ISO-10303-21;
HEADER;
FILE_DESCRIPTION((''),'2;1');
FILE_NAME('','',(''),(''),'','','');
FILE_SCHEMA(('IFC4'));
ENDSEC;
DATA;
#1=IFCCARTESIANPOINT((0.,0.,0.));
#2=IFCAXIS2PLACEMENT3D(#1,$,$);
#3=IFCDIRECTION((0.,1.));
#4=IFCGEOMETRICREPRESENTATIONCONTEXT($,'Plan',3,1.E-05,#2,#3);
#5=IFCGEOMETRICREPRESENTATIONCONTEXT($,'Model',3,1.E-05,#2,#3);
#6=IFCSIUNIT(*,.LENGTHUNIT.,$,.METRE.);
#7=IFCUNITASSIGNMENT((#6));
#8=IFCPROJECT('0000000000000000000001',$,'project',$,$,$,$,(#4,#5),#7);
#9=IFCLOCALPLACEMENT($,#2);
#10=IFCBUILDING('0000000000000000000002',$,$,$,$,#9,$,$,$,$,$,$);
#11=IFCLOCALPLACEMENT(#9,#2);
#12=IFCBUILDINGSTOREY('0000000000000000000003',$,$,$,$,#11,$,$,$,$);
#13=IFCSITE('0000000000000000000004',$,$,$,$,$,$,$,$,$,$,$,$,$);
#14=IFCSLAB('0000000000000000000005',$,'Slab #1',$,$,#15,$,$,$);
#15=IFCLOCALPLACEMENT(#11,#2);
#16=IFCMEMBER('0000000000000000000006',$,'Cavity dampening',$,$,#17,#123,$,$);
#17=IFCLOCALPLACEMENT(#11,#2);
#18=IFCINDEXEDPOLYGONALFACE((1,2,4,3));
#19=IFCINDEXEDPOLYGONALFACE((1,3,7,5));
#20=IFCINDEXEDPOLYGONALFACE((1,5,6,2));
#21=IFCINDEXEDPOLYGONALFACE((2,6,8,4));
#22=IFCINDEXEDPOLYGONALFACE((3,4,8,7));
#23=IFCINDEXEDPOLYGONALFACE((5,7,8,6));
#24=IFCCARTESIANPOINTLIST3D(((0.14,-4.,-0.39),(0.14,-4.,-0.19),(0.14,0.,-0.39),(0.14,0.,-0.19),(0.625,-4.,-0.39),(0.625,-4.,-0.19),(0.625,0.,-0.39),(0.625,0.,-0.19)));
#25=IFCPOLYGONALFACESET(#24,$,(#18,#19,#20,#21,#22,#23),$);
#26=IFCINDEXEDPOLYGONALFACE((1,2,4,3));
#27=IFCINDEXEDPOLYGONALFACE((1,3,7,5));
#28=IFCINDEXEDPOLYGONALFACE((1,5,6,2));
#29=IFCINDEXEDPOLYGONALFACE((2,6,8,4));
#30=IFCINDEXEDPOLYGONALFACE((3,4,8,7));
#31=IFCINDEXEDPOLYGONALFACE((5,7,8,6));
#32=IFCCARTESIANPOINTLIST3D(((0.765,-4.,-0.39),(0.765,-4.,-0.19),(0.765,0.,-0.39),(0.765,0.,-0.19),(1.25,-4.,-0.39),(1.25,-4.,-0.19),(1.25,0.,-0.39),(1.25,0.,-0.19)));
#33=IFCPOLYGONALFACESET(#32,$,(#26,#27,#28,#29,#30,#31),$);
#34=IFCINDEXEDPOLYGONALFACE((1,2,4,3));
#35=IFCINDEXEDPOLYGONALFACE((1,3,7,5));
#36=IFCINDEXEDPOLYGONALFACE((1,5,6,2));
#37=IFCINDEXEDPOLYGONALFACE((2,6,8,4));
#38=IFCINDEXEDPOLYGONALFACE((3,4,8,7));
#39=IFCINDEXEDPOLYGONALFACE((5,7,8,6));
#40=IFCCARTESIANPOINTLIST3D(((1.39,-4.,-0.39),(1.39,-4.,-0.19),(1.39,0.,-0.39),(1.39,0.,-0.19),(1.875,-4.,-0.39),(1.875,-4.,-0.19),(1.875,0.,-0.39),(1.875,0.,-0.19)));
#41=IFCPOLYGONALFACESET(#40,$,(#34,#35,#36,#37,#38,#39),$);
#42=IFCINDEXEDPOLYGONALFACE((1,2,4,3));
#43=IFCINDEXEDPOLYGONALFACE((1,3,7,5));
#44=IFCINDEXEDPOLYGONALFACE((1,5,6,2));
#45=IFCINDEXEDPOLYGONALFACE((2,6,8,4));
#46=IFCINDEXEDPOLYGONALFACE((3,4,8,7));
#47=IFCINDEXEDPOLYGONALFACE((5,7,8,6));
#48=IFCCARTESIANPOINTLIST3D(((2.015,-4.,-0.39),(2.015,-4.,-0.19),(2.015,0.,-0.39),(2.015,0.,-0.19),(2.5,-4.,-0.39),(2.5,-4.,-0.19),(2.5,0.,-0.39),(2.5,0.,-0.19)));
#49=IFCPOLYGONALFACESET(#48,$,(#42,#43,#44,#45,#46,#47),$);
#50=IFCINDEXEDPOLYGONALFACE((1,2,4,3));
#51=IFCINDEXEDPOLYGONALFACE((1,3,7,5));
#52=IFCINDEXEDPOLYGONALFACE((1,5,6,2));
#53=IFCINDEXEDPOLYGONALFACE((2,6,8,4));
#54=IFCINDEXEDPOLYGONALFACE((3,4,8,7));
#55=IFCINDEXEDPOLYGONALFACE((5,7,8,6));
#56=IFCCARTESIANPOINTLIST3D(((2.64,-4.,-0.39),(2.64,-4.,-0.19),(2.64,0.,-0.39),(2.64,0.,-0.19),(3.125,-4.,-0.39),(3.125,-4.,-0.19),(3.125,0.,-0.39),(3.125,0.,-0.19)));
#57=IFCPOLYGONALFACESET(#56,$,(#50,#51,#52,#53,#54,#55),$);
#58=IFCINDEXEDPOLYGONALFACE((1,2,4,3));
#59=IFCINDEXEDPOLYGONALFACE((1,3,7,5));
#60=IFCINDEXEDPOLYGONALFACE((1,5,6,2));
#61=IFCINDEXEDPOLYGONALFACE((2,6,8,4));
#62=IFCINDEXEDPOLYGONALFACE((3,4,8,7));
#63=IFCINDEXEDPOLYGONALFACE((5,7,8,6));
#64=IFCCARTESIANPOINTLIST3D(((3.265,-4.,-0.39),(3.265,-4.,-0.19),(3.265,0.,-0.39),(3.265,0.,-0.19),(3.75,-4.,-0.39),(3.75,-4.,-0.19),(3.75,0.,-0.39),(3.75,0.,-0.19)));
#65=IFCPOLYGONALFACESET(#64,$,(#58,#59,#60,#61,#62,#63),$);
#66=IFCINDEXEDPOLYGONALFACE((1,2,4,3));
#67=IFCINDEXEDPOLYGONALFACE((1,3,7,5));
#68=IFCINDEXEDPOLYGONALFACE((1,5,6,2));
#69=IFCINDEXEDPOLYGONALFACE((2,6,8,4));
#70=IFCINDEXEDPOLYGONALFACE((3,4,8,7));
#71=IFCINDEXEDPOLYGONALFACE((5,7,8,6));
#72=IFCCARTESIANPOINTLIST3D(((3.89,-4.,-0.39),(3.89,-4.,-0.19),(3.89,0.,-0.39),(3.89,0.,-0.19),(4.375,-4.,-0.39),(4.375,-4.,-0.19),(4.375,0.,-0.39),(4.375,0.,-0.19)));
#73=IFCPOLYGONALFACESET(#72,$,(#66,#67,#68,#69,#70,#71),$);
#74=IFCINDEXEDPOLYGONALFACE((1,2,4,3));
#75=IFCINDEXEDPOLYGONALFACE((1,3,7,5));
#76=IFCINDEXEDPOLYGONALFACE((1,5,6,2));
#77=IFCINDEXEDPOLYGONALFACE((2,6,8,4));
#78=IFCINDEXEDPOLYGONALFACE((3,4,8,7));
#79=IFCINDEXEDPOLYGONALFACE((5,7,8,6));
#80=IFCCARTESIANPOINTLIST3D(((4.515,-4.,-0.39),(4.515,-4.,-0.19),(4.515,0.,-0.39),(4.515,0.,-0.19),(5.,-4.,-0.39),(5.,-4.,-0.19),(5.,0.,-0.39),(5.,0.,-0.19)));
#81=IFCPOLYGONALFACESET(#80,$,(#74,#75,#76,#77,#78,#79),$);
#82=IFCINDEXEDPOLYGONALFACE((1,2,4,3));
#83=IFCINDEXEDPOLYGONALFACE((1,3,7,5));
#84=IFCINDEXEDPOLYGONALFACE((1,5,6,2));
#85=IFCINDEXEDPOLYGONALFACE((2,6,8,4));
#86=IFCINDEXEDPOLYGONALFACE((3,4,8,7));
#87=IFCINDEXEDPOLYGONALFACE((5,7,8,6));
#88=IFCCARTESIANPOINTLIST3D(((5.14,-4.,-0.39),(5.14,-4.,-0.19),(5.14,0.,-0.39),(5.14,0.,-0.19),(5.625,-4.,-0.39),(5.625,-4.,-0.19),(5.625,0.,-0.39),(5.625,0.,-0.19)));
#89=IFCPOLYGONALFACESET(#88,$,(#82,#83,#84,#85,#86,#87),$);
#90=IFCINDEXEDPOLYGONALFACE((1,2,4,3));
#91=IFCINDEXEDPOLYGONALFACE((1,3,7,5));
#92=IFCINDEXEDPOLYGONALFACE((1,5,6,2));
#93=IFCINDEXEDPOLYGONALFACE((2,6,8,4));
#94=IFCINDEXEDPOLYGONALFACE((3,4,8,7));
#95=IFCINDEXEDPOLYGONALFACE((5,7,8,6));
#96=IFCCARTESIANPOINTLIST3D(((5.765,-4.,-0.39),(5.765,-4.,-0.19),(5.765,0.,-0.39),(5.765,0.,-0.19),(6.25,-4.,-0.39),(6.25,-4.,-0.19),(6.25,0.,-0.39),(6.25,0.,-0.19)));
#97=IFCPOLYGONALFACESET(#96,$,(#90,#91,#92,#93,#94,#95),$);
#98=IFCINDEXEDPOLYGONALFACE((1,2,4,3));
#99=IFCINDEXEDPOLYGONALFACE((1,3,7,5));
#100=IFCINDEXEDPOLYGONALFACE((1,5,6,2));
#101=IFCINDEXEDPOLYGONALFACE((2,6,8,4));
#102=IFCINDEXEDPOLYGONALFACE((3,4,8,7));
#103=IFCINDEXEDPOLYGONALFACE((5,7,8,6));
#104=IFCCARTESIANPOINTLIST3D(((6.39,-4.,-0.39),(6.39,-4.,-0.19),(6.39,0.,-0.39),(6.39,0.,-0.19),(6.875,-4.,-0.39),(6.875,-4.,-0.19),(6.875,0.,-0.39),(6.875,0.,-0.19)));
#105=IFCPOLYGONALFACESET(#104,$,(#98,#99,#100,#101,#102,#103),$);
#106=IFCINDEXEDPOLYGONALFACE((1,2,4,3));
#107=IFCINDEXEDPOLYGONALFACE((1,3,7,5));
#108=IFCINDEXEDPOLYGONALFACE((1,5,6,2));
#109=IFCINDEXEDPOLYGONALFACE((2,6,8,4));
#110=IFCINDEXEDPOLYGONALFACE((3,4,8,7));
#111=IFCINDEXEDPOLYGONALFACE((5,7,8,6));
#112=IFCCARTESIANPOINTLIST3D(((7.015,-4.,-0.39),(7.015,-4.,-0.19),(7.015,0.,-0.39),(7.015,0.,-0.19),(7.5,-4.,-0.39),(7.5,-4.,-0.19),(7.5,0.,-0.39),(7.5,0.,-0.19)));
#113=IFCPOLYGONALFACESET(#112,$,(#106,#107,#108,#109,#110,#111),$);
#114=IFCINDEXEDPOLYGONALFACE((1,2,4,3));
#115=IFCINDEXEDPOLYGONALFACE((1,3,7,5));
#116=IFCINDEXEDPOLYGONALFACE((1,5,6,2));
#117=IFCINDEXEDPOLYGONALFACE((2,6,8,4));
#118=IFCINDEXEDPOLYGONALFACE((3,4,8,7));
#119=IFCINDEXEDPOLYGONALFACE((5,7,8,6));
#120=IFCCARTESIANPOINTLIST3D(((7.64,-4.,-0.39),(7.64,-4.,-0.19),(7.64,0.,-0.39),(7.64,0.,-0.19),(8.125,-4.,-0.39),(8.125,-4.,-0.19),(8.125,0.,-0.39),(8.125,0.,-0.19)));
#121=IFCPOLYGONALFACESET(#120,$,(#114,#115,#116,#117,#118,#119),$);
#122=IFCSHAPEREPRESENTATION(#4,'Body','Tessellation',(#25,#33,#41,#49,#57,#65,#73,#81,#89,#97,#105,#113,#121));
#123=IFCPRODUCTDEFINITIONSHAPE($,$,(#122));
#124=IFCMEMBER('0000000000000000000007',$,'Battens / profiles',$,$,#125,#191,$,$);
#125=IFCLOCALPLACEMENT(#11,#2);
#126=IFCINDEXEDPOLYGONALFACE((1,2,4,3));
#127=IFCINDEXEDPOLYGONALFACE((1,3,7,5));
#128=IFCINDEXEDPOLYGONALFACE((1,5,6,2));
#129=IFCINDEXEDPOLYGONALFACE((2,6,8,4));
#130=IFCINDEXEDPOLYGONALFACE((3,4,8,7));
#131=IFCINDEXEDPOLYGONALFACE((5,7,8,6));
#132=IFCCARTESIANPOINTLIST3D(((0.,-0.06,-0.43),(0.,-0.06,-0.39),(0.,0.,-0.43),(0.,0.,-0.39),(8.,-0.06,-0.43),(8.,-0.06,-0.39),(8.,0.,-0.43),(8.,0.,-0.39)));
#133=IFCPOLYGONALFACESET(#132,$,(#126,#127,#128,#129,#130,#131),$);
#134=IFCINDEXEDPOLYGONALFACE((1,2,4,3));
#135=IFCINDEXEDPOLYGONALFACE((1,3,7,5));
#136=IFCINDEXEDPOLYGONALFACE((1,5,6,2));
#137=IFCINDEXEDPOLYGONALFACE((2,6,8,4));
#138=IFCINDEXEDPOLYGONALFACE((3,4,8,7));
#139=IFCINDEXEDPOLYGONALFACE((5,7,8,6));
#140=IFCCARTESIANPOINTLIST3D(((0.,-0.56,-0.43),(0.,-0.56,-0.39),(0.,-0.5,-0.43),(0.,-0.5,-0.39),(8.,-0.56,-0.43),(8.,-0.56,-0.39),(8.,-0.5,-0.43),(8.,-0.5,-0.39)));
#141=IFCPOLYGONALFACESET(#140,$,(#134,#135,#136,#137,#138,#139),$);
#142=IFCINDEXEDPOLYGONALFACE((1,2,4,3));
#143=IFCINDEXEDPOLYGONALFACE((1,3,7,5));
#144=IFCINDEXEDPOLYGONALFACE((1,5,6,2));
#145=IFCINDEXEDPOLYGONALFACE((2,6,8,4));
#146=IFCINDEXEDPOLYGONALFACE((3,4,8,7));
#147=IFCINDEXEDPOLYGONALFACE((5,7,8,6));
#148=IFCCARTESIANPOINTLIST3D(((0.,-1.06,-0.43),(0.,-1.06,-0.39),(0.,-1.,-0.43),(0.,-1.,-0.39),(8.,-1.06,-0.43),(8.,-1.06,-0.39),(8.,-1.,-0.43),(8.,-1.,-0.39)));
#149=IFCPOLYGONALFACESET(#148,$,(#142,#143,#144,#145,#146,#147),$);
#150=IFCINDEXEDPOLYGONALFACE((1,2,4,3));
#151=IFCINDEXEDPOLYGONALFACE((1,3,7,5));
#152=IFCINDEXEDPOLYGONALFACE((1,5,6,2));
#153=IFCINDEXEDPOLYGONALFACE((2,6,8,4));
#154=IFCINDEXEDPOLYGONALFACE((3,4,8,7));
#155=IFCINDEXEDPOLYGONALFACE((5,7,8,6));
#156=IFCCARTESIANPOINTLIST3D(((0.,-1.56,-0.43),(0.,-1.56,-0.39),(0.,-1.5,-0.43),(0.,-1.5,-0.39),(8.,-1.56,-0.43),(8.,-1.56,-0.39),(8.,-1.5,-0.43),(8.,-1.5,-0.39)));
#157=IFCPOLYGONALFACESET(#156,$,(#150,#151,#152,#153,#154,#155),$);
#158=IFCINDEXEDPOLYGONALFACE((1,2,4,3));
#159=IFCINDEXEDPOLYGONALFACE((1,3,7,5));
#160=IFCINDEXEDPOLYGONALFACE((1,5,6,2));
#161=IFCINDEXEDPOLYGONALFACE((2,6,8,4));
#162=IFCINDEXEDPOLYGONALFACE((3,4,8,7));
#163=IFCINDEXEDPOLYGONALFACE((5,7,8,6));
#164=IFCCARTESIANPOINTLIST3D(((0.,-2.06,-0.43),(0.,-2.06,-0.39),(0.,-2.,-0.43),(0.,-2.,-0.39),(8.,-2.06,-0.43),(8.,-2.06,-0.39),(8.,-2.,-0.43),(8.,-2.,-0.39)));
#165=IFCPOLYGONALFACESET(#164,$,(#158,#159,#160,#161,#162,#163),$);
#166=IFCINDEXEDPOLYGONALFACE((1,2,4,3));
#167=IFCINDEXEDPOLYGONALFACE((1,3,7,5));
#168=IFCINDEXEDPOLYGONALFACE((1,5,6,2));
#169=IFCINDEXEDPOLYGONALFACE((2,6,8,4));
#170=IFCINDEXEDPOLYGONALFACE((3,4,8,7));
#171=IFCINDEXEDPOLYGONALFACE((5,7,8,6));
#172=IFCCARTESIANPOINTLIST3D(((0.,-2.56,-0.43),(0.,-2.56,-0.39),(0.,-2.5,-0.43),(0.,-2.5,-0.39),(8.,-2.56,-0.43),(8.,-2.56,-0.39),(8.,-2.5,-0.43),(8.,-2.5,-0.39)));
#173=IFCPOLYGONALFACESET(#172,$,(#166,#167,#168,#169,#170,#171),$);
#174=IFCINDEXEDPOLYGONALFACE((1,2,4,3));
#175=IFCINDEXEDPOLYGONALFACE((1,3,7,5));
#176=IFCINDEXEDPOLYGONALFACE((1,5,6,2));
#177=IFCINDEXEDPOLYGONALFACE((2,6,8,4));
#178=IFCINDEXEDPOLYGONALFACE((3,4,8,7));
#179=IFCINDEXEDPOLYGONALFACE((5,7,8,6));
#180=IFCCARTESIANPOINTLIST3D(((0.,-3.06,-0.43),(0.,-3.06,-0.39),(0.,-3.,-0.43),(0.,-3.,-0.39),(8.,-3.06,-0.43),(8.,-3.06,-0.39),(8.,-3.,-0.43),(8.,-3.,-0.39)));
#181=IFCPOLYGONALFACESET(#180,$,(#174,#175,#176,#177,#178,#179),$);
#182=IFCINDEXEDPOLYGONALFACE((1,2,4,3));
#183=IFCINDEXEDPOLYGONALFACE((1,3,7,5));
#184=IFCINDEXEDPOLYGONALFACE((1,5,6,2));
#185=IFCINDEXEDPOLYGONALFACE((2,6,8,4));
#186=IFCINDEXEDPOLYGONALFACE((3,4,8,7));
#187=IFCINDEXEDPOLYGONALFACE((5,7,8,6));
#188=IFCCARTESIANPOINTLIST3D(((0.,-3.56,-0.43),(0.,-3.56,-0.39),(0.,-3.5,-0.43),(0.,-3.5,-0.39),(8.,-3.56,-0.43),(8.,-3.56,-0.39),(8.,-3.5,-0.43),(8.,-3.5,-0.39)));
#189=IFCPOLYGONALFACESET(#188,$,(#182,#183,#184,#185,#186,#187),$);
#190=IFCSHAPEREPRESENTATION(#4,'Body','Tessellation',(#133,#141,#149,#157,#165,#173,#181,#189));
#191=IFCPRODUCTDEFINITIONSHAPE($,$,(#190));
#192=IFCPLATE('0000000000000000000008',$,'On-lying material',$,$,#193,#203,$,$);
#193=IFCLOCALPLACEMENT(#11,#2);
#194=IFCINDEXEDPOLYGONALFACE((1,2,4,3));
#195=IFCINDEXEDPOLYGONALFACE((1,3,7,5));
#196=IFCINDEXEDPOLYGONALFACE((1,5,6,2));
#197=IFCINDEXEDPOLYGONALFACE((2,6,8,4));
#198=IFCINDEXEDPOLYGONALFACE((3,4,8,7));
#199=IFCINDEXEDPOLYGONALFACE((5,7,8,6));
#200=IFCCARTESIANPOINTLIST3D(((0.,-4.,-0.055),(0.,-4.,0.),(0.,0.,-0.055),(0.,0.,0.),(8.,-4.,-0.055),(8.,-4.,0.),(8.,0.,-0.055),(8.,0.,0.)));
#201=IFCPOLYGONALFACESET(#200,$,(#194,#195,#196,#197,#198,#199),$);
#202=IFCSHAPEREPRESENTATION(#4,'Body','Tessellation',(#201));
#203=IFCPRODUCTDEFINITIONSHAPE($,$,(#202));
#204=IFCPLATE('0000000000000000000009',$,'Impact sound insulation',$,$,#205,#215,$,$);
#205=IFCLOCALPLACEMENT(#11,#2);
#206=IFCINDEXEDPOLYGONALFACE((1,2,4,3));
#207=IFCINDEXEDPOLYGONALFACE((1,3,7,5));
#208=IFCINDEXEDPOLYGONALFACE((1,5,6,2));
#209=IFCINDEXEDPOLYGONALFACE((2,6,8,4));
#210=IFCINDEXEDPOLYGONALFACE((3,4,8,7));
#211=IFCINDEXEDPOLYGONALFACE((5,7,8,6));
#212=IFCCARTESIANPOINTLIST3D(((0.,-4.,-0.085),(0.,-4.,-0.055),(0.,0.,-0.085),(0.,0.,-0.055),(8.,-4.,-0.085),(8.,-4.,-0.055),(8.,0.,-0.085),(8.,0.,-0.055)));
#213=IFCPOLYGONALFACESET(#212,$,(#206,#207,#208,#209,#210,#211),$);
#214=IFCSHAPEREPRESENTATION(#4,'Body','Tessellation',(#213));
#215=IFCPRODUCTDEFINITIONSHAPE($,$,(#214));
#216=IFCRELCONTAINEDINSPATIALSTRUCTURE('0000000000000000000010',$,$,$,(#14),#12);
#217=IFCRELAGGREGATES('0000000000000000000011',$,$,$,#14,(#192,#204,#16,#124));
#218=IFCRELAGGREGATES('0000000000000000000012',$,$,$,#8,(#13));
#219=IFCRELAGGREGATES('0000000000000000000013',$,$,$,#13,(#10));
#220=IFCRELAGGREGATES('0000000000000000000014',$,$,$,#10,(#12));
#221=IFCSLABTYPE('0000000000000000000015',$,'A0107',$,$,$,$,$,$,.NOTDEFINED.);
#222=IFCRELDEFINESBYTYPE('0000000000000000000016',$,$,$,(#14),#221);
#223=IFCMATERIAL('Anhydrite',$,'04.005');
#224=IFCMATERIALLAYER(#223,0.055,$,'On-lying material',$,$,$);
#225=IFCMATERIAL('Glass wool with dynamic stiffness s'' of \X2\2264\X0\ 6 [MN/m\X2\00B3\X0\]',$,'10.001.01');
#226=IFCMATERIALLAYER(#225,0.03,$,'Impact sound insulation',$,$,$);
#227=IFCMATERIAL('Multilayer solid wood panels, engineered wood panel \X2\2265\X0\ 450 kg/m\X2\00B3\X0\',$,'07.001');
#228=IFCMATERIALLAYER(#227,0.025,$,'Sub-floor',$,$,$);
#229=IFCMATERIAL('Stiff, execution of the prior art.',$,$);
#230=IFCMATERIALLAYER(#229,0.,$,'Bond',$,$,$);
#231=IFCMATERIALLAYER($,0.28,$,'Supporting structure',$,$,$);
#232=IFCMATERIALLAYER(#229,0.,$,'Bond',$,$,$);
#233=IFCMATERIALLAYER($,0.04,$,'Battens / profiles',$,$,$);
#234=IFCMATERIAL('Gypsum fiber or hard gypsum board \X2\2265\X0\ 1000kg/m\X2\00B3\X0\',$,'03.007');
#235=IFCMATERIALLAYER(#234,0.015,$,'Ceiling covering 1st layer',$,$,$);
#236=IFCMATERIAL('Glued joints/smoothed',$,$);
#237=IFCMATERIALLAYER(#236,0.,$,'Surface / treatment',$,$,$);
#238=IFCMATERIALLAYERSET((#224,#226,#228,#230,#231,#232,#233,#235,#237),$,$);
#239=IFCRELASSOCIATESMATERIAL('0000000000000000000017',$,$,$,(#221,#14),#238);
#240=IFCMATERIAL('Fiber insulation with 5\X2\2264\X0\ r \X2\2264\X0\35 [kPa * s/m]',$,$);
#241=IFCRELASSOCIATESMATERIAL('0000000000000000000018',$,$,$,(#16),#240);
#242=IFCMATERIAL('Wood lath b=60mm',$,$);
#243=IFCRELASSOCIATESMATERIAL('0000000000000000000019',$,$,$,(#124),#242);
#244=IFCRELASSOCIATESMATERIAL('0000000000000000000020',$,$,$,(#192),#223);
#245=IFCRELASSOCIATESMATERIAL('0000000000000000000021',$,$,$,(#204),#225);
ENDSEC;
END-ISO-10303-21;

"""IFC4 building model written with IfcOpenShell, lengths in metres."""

from ifc_helpers import new_model, si_unit, direction, frame, frame_2d, origin, origin_with_axes, place, context, project, spatial, rectangle, extrude, material, layer, layer_set, type_object, element, aggregate, save


model = new_model("IFC4")

# Units and contexts
plan_context = context("Plan", 3, precision=1e-05, world=origin(), true_north=direction((0.0, 1.0)))
model_context = context("Model", 3, precision=1e-05, world=origin(), true_north=direction((0.0, 1.0)))
ifc_project = project(units=[si_unit("LENGTHUNIT", "METRE")], contexts=[plan_context, model_context])

# Site, building, storey
site = spatial("IfcSite", under=ifc_project)
building_placement = place(None, origin())
building = spatial("IfcBuilding", under=site, at=building_placement)
storey_placement = place(building_placement, origin())
storey = spatial("IfcBuildingStorey", under=building, at=storey_placement)

# Slab, members, plates
ifc_material_1 = material(Name="Anhydrite", Category="04.005")
ifc_layer_1 = layer(ifc_material_1, 0.055, Name="On-lying material")
ifc_material_2 = material(Name="Glass wool with dynamic stiffness s' of ≤ 6 [MN/m³]", Category="10.001.01")
ifc_layer_2 = layer(ifc_material_2, 0.03, Name="Impact sound insulation")
ifc_material_3 = material(Name="Multilayer solid wood panels, engineered wood panel ≥ 450 kg/m³", Category="07.001")
ifc_layer_3 = layer(ifc_material_3, 0.025, Name="Sub-floor")
ifc_material_4 = material(Name="Stiff, execution of the prior art.")
ifc_layer_4 = layer(ifc_material_4, 0.0, Name="Bond")
ifc_layer_5 = layer(None, 0.28, Name="Supporting structure")
ifc_layer_6 = layer(ifc_material_4, 0.0, Name="Bond")
ifc_layer_7 = layer(None, 0.04, Name="Battens / profiles")
ifc_material_5 = material(Name="Gypsum fiber or hard gypsum board ≥ 1000kg/m³", Category="03.007")
ifc_layer_8 = layer(ifc_material_5, 0.015, Name="Ceiling covering 1st layer")
ifc_material_6 = material(Name="Glued joints/smoothed")
ifc_layer_9 = layer(ifc_material_6, 0.0, Name="Surface / treatment")
ifc_layer_set = layer_set([ifc_layer_1, ifc_layer_2, ifc_layer_3, ifc_layer_4, ifc_layer_5, ifc_layer_6, ifc_layer_7, ifc_layer_8, ifc_layer_9])
slab_type = type_object("IfcSlabType", Name="A0107", PredefinedType="NOTDEFINED", material=ifc_layer_set)
slab_placement = place(None, frame((0.0, 0.0, 0.0), z_axis=(0.0, 0.0, -1.0), x_axis=(1.0, 0.0, 0.0)))
slab = element("IfcSlab", 1, at=slab_placement, inside=storey, type_object=slab_type, material=ifc_layer_set, Name="Slab #1")
ifc_material_7 = material(Name="Fiber insulation with 5≤ r ≤35 [kPa * s/m]")
member_1_placement = place(slab_placement, origin())
member_1 = element("IfcMember", 2, at=member_1_placement, material=ifc_material_7, Name="Cavity dampening", context=plan_context, shape_type="SweptSolid", body=[
    extrude(rectangle(XDim=0.485, YDim=0.2, at=frame_2d((0.2425, 0.1), x_axis=(1.0, 0.0))), frame((0.14, 4.0, 0.19), z_axis=(0.0, -1.0, 0.0), x_axis=(1.0, 0.0, 0.0)), (0.0, 0.0, 1.0), 4.0),
    extrude(rectangle(XDim=0.485, YDim=0.2, at=frame_2d((0.2425, 0.1), x_axis=(1.0, 0.0))), frame((0.765, 4.0, 0.19), z_axis=(0.0, -1.0, 0.0), x_axis=(1.0, 0.0, 0.0)), (0.0, 0.0, 1.0), 4.0),
    extrude(rectangle(XDim=0.485, YDim=0.2, at=frame_2d((0.2425, 0.1), x_axis=(1.0, 0.0))), frame((1.39, 4.0, 0.19), z_axis=(0.0, -1.0, 0.0), x_axis=(1.0, 0.0, 0.0)), (0.0, 0.0, 1.0), 4.0),
    extrude(rectangle(XDim=0.485, YDim=0.2, at=frame_2d((0.2425, 0.1), x_axis=(1.0, 0.0))), frame((2.015, 4.0, 0.19), z_axis=(0.0, -1.0, 0.0), x_axis=(1.0, 0.0, 0.0)), (0.0, 0.0, 1.0), 4.0),
    extrude(rectangle(XDim=0.485, YDim=0.2, at=frame_2d((0.2425, 0.1), x_axis=(1.0, 0.0))), frame((2.64, 4.0, 0.19), z_axis=(0.0, -1.0, 0.0), x_axis=(1.0, 0.0, 0.0)), (0.0, 0.0, 1.0), 4.0),
    extrude(rectangle(XDim=0.485, YDim=0.2, at=frame_2d((0.2425, 0.1), x_axis=(1.0, 0.0))), frame((3.265, 4.0, 0.19), z_axis=(0.0, -1.0, 0.0), x_axis=(1.0, 0.0, 0.0)), (0.0, 0.0, 1.0), 4.0),
    extrude(rectangle(XDim=0.485, YDim=0.2, at=frame_2d((0.2425, 0.1), x_axis=(1.0, 0.0))), frame((3.89, 4.0, 0.19), z_axis=(0.0, -1.0, 0.0), x_axis=(1.0, 0.0, 0.0)), (0.0, 0.0, 1.0), 4.0),
    extrude(rectangle(XDim=0.485, YDim=0.2, at=frame_2d((0.2425, 0.1), x_axis=(1.0, 0.0))), frame((4.515, 4.0, 0.19), z_axis=(0.0, -1.0, 0.0), x_axis=(1.0, 0.0, 0.0)), (0.0, 0.0, 1.0), 4.0),
    extrude(rectangle(XDim=0.485, YDim=0.2, at=frame_2d((0.2425, 0.1), x_axis=(1.0, 0.0))), frame((5.14, 4.0, 0.19), z_axis=(0.0, -1.0, 0.0), x_axis=(1.0, 0.0, 0.0)), (0.0, 0.0, 1.0), 4.0),
    extrude(rectangle(XDim=0.485, YDim=0.2, at=frame_2d((0.2425, 0.1), x_axis=(1.0, 0.0))), frame((5.765, 4.0, 0.19), z_axis=(0.0, -1.0, 0.0), x_axis=(1.0, 0.0, 0.0)), (0.0, 0.0, 1.0), 4.0),
    extrude(rectangle(XDim=0.485, YDim=0.2, at=frame_2d((0.2425, 0.1), x_axis=(1.0, 0.0))), frame((6.39, 4.0, 0.19), z_axis=(0.0, -1.0, 0.0), x_axis=(1.0, 0.0, 0.0)), (0.0, 0.0, 1.0), 4.0),
    extrude(rectangle(XDim=0.485, YDim=0.2, at=frame_2d((0.2425, 0.1), x_axis=(1.0, 0.0))), frame((7.015, 4.0, 0.19), z_axis=(0.0, -1.0, 0.0), x_axis=(1.0, 0.0, 0.0)), (0.0, 0.0, 1.0), 4.0),
    extrude(rectangle(XDim=0.485, YDim=0.2, at=frame_2d((0.2425, 0.1), x_axis=(1.0, 0.0))), frame((7.64, 4.0, 0.19), z_axis=(0.0, -1.0, 0.0), x_axis=(1.0, 0.0, 0.0)), (0.0, 0.0, 1.0), 4.0),
])
ifc_material_8 = material(Name="Wood lath b=60mm")
member_2_placement = place(slab_placement, origin())
member_2 = element("IfcMember", 3, at=member_2_placement, material=ifc_material_8, Name="Battens / profiles", context=plan_context, shape_type="SweptSolid", body=[
    extrude(rectangle(XDim=0.06, YDim=0.04, at=frame_2d((0.03, 0.02), x_axis=(1.0, 0.0))), frame((0.0, 0.0, 0.39), z_axis=(1.0, 0.0, 0.0), x_axis=(0.0, 1.0, 0.0)), (0.0, 0.0, 1.0), 8.0),
    extrude(rectangle(XDim=0.06, YDim=0.04, at=frame_2d((0.03, 0.02), x_axis=(1.0, 0.0))), frame((0.0, 0.5, 0.39), z_axis=(1.0, 0.0, 0.0), x_axis=(0.0, 1.0, 0.0)), (0.0, 0.0, 1.0), 8.0),
    extrude(rectangle(XDim=0.06, YDim=0.04, at=frame_2d((0.03, 0.02), x_axis=(1.0, 0.0))), frame((0.0, 1.0, 0.39), z_axis=(1.0, 0.0, 0.0), x_axis=(0.0, 1.0, 0.0)), (0.0, 0.0, 1.0), 8.0),
    extrude(rectangle(XDim=0.06, YDim=0.04, at=frame_2d((0.03, 0.02), x_axis=(1.0, 0.0))), frame((0.0, 1.5, 0.39), z_axis=(1.0, 0.0, 0.0), x_axis=(0.0, 1.0, 0.0)), (0.0, 0.0, 1.0), 8.0),
    extrude(rectangle(XDim=0.06, YDim=0.04, at=frame_2d((0.03, 0.02), x_axis=(1.0, 0.0))), frame((0.0, 2.0, 0.39), z_axis=(1.0, 0.0, 0.0), x_axis=(0.0, 1.0, 0.0)), (0.0, 0.0, 1.0), 8.0),
    extrude(rectangle(XDim=0.06, YDim=0.04, at=frame_2d((0.03, 0.02), x_axis=(1.0, 0.0))), frame((0.0, 2.5, 0.39), z_axis=(1.0, 0.0, 0.0), x_axis=(0.0, 1.0, 0.0)), (0.0, 0.0, 1.0), 8.0),
    extrude(rectangle(XDim=0.06, YDim=0.04, at=frame_2d((0.03, 0.02), x_axis=(1.0, 0.0))), frame((0.0, 3.0, 0.39), z_axis=(1.0, 0.0, 0.0), x_axis=(0.0, 1.0, 0.0)), (0.0, 0.0, 1.0), 8.0),
    extrude(rectangle(XDim=0.06, YDim=0.04, at=frame_2d((0.03, 0.02), x_axis=(1.0, 0.0))), frame((0.0, 3.5, 0.39), z_axis=(1.0, 0.0, 0.0), x_axis=(0.0, 1.0, 0.0)), (0.0, 0.0, 1.0), 8.0),
])
plate_1_placement = place(slab_placement, origin())
plate_1 = element("IfcPlate", 4, at=plate_1_placement, material=ifc_material_1, Name="On-lying material", context=plan_context, shape_type="SweptSolid", body=[
    extrude(rectangle(XDim=8.0, YDim=4.0, at=frame_2d((4.0, 2.0), x_axis=(1.0, 0.0))), origin_with_axes(), (0.0, 0.0, 1.0), 0.055),
])
plate_2_placement = place(slab_placement, origin())
plate_2 = element("IfcPlate", 5, at=plate_2_placement, material=ifc_material_2, Name="Impact sound insulation", context=plan_context, shape_type="SweptSolid", body=[
    extrude(rectangle(XDim=8.0, YDim=4.0, at=frame_2d((4.0, 2.0), x_axis=(1.0, 0.0))), frame((0.0, 0.0, 0.055), z_axis=(0.0, 0.0, 1.0), x_axis=(1.0, 0.0, 0.0)), (0.0, 0.0, 1.0), 0.03),
])
aggregate(slab, [plate_1, plate_2, member_1, member_2])

save(model, "model.ifc")
